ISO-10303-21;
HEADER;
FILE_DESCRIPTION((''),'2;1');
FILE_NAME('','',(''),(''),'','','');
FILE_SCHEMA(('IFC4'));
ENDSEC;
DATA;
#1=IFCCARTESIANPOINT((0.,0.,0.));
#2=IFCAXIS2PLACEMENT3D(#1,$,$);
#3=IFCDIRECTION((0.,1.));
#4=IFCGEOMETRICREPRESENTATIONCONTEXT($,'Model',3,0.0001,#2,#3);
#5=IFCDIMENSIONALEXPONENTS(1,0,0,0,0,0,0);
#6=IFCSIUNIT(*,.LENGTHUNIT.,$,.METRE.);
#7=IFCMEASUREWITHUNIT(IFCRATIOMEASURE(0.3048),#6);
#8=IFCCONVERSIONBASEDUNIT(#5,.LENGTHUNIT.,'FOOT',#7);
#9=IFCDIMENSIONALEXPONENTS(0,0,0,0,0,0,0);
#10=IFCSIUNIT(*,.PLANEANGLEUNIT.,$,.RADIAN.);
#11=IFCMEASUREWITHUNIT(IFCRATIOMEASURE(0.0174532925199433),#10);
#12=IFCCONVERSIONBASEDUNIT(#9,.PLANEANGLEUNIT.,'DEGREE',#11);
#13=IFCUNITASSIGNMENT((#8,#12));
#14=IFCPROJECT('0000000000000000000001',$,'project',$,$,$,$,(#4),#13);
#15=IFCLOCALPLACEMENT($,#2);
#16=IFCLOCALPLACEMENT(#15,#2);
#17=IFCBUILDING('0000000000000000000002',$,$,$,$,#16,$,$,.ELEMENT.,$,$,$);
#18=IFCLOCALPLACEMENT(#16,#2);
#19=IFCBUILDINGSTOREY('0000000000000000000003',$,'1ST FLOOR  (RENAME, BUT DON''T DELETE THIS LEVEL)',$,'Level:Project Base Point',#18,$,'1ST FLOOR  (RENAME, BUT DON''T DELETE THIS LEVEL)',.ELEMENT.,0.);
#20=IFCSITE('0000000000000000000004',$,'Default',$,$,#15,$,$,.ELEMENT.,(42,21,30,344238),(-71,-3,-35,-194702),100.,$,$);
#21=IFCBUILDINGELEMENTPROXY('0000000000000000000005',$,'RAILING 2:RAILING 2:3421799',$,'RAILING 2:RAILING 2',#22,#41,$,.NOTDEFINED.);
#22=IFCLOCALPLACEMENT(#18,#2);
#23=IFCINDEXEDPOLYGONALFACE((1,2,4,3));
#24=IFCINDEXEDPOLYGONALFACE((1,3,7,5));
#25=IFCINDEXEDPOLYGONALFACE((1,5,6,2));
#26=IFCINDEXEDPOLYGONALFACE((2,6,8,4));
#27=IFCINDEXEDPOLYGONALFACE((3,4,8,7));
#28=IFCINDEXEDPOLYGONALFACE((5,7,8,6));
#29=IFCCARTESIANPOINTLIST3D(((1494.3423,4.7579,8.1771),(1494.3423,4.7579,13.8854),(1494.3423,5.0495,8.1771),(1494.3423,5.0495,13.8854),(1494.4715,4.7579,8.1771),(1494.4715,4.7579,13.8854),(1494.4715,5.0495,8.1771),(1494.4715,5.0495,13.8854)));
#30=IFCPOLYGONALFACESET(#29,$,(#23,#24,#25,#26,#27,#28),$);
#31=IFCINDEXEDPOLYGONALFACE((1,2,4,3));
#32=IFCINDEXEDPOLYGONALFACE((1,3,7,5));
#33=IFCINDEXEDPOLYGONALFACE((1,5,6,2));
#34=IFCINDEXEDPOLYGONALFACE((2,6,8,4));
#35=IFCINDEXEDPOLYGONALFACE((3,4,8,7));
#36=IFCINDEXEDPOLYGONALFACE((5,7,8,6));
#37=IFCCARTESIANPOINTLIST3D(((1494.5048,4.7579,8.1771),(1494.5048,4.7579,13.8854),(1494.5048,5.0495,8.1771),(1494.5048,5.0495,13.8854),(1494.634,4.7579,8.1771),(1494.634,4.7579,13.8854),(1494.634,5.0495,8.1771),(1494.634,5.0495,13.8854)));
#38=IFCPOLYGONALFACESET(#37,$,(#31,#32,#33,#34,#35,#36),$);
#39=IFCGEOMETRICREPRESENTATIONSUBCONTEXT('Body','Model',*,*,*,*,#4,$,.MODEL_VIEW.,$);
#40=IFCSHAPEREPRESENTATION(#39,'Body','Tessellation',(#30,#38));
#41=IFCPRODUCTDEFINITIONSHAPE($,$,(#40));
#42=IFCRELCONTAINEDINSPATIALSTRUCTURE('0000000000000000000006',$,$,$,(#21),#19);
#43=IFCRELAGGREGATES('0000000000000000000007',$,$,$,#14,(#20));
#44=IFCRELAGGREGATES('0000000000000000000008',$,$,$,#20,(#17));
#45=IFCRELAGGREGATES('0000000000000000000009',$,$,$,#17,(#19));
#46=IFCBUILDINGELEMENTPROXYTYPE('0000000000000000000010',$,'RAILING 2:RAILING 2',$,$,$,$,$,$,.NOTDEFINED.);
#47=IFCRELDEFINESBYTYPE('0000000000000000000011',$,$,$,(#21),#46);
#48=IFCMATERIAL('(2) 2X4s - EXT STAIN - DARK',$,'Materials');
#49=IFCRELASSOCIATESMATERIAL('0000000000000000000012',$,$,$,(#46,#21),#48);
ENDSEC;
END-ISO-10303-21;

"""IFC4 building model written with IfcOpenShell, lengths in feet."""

from ifc_helpers import new_model, entity, si_unit, converted_unit, direction, frame, frame_2d, origin, place, context, subcontext, project, spatial, rectangle, extrude, source, transform, mapped, material, type_object, type_shapes, element, save


model = new_model("IFC4")

# Units and contexts
model_context = context("Model", 3, precision=0.0001, world=origin(), true_north=direction((0.0, 1.0)))
body_context = subcontext(model_context, "Body", "Model", "MODEL_VIEW")
ifc_project = project(units=[converted_unit("LENGTHUNIT", "FOOT", entity("IfcRatioMeasure", 0.3048), si_unit("LENGTHUNIT", "METRE"), dimensions=[1, 0, 0, 0, 0, 0, 0]), converted_unit("PLANEANGLEUNIT", "DEGREE", entity("IfcRatioMeasure", 0.0174532925199433), si_unit("PLANEANGLEUNIT", "RADIAN"), dimensions=[0, 0, 0, 0, 0, 0, 0])], contexts=[model_context])

# Site, building, storey
site_placement = place(None, origin())
site = spatial("IfcSite", under=ifc_project, at=site_placement, Name="Default", CompositionType="ELEMENT", RefLatitude=(42, 21, 30, 344238), RefLongitude=(-71, -3, -35, -194702), RefElevation=100.0)
building_placement = place(site_placement, origin())
building = spatial("IfcBuilding", under=site, at=building_placement, CompositionType="ELEMENT")
storey_placement = place(building_placement, origin())
storey = spatial("IfcBuildingStorey", under=building, at=storey_placement, Name="1ST FLOOR  (RENAME, BUT DON'T DELETE THIS LEVEL)", ObjectType="Level:Project Base Point", LongName="1ST FLOOR  (RENAME, BUT DON'T DELETE THIS LEVEL)", CompositionType="ELEMENT", Elevation=0.0)

# Building element proxy
ifc_material_1 = material(Name="(2) 2X4s - EXT STAIN - DARK", Category="Materials")
building_element_proxy_type_1 = type_object("IfcBuildingElementProxyType", Name="RAILING 2:RAILING 2", PredefinedType="NOTDEFINED", material=ifc_material_1)
shared_shape_1 = source(origin(), body_context, "Body", "SweptSolid", [
    extrude(rectangle(XDim=0.2917, YDim=0.1292, at=frame_2d((0.0, 0.0), x_axis=(1.0, 0.0))), frame((0.0646, 0.1458, 0.0), z_axis=(0.0, 0.0, 1.0), x_axis=(0.0, -1.0, 0.0)), (0.0, 0.0, 1.0), 5.7083),
    extrude(rectangle(XDim=0.1292, YDim=0.2917, at=frame_2d((0.0, 0.0), x_axis=(1.0, 0.0))), frame((0.2271, 0.1458, 0.0), z_axis=(0.0, 0.0, 1.0), x_axis=(-1.0, 0.0, 0.0)), (0.0, 0.0, 1.0), 5.7083),
])
type_shapes(building_element_proxy_type_1, [shared_shape_1])
proxy_1_placement = place(storey_placement, frame((1494.3423, 4.7579, 8.1771)))
element("IfcBuildingElementProxy", 1, at=proxy_1_placement, inside=storey, type_object=building_element_proxy_type_1, material=ifc_material_1, Name="RAILING 2:RAILING 2:3421799", ObjectType="RAILING 2:RAILING 2", PredefinedType="NOTDEFINED", context=body_context, shape_type="MappedRepresentation", body=[
    mapped(shared_shape_1, transform((0.0, 0.0, 0.0), scale=1.0)),
])

save(model, "model.ifc")
